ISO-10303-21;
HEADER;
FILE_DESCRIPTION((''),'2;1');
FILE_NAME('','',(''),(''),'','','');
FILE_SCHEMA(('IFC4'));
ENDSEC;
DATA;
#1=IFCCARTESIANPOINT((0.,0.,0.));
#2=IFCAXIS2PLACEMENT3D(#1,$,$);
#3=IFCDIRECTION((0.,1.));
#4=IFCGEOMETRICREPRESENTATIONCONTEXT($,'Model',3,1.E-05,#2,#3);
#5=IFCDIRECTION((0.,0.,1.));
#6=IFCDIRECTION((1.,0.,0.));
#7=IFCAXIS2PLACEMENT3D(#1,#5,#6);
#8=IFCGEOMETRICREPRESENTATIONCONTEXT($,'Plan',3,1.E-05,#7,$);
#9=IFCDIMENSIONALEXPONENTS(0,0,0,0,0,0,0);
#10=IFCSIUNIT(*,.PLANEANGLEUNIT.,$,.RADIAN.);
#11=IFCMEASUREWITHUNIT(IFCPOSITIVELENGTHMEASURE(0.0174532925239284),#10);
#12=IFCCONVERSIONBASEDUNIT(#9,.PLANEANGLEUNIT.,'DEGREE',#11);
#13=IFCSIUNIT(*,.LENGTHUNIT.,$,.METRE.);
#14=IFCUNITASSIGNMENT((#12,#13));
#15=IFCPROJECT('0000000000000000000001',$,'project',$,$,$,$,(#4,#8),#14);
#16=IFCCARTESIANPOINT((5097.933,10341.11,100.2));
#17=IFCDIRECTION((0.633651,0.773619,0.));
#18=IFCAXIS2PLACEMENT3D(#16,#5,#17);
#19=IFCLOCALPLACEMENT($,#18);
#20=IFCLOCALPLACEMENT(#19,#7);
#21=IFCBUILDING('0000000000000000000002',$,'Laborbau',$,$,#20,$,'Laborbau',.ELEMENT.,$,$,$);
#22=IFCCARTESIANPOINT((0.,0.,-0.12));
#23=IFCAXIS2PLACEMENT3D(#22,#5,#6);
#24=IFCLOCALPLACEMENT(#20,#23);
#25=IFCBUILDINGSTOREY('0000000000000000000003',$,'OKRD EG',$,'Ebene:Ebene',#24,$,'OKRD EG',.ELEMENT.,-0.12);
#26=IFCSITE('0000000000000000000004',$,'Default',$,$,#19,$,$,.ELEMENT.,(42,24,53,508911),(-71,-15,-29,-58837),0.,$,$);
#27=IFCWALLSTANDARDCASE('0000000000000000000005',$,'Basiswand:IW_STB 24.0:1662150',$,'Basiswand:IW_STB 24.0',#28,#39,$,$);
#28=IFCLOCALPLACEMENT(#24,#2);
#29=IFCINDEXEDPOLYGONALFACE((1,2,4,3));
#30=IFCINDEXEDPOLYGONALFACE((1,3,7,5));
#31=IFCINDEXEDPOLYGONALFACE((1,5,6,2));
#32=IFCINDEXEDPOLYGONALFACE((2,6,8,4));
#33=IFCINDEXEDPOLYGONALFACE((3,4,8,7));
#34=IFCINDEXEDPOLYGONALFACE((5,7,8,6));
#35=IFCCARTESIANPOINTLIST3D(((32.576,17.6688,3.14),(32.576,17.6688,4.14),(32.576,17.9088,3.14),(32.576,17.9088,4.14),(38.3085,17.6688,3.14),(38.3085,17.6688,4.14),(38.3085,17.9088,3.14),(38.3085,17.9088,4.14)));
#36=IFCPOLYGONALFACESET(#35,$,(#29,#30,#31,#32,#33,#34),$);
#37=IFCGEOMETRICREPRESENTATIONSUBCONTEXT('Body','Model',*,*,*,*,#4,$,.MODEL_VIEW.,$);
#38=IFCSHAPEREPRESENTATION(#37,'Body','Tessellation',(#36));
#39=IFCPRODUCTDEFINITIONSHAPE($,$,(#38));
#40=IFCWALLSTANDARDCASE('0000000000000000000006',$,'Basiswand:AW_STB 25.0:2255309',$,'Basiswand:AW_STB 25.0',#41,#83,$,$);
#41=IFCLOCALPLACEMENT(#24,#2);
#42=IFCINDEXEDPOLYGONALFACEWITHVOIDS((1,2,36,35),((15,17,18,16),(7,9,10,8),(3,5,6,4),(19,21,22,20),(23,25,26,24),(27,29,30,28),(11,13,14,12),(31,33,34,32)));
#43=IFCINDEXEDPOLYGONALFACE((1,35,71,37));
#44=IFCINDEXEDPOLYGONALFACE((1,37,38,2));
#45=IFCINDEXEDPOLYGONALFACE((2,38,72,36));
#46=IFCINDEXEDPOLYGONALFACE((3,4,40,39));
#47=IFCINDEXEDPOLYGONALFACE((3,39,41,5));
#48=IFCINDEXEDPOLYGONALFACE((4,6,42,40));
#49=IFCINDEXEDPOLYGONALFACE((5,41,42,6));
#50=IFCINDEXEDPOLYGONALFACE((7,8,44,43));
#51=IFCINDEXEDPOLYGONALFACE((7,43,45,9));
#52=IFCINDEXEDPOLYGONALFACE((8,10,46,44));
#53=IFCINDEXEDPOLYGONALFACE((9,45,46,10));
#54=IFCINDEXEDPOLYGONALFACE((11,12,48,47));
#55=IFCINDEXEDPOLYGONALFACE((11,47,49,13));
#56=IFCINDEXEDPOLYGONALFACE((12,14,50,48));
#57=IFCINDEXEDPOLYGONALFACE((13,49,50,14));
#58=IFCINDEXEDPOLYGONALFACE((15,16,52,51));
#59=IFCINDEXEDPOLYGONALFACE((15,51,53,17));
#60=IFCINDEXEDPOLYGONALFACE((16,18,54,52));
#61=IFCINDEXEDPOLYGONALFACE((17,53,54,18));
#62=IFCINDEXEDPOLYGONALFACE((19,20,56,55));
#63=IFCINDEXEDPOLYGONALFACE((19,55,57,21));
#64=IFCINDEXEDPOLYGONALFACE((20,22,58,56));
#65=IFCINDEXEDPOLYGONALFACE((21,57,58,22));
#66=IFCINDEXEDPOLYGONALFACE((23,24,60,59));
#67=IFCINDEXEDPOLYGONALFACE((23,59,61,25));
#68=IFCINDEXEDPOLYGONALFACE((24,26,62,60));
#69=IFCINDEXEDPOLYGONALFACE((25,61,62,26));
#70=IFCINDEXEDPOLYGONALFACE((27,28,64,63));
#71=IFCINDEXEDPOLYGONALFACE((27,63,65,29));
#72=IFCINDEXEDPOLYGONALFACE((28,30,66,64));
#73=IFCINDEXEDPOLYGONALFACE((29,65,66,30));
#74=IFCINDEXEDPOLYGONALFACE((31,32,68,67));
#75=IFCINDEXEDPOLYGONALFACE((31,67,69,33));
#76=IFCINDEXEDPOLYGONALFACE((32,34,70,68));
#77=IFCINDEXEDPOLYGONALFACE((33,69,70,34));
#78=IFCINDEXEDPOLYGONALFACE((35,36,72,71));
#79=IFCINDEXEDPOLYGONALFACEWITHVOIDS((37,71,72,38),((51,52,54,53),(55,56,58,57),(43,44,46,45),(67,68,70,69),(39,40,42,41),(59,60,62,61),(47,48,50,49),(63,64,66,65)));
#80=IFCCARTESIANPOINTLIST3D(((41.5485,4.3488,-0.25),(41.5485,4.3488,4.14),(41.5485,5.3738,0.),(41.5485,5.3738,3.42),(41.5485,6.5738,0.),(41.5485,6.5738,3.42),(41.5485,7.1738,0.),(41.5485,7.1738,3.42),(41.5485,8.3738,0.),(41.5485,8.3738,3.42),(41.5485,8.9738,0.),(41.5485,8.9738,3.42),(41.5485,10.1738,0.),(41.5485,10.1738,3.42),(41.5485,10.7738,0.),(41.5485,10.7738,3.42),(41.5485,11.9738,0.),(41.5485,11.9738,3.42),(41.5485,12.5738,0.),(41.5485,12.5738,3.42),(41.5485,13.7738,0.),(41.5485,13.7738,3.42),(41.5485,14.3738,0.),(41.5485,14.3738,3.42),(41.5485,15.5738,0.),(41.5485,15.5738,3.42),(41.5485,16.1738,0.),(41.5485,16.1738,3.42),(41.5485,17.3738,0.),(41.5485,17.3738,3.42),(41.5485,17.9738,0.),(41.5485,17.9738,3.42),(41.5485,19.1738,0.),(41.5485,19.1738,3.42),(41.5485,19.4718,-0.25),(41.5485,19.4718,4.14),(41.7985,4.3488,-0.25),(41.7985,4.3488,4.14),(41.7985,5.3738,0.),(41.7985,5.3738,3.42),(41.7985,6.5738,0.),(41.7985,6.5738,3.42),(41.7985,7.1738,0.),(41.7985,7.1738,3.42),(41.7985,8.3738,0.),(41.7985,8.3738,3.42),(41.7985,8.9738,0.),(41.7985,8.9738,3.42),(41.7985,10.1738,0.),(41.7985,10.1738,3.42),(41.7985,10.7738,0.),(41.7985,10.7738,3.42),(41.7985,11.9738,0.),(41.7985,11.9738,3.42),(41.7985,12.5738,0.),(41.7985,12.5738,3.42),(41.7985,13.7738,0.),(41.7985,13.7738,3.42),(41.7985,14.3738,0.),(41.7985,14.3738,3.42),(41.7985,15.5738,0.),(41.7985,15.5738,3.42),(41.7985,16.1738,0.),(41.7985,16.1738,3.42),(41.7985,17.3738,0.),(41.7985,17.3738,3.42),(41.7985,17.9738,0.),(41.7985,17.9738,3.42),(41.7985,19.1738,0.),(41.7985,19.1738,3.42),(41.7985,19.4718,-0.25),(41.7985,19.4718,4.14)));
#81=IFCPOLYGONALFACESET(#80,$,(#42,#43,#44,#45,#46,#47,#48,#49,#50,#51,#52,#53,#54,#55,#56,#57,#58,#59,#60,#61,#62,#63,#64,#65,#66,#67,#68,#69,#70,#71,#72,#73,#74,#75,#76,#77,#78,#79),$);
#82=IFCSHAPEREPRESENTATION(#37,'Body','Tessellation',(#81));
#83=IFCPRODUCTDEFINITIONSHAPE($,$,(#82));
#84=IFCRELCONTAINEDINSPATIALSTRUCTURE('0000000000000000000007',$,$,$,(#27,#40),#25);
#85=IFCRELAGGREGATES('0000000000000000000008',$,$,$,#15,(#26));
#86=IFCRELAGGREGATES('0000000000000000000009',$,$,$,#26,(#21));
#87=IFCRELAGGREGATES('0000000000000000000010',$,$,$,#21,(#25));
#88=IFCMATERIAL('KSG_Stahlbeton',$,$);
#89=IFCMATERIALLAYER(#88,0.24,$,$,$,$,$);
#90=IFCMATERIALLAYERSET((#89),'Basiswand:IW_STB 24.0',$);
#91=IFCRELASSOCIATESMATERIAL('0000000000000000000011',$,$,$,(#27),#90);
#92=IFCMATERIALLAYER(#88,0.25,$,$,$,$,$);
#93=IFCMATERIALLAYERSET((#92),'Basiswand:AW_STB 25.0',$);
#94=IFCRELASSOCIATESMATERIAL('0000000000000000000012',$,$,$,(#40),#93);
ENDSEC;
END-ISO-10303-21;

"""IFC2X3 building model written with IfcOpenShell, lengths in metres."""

from ifc_helpers import new_model, entity, si_unit, converted_unit, direction, frame, frame_2d, origin, origin_with_axes, place, context, subcontext, project, spatial, rectangle, extrude, material, layer, layer_set, layer_usage, element, save


model = new_model("IFC2X3")

# Units and contexts
model_context = context("Model", 3, precision=1e-05, world=origin(), true_north=direction((0.0, 1.0)))
plan_context = context("Plan", 3, precision=1e-05, world=origin_with_axes())
body_context = subcontext(model_context, "Body", "Model", "MODEL_VIEW")
ifc_project = project(units=[converted_unit("PLANEANGLEUNIT", "DEGREE", entity("IfcPositiveLengthMeasure", 0.0174532925239284), si_unit("PLANEANGLEUNIT", "RADIAN"), dimensions=[0, 0, 0, 0, 0, 0, 0]), si_unit("LENGTHUNIT", "METRE")], contexts=[model_context, plan_context])

# Site, building, storey
site_placement = place(None, frame((5097.933, 10341.11, 100.2), z_axis=(0.0, 0.0, 1.0), x_axis=(0.633651, 0.773619, 0.0)))
site = spatial("IfcSite", under=ifc_project, at=site_placement, Name="Default", CompositionType="ELEMENT", RefLatitude=(42, 24, 53, 508911), RefLongitude=(-71, -15, -29, -58837), RefElevation=0.0)
building_placement = place(site_placement, origin_with_axes())
building = spatial("IfcBuilding", under=site, at=building_placement, Name="Laborbau", LongName="Laborbau", CompositionType="ELEMENT")
storey_placement = place(building_placement, frame((0.0, 0.0, -0.12), z_axis=(0.0, 0.0, 1.0), x_axis=(1.0, 0.0, 0.0)))
storey = spatial("IfcBuildingStorey", under=building, at=storey_placement, Name="OKRD EG", ObjectType="Ebene:Ebene", LongName="OKRD EG", CompositionType="ELEMENT", Elevation=-0.12)

# Shared definitions
ifc_material_1 = material(Name="KSG_Stahlbeton")

# Shared definitions
ifc_layer_1 = layer(ifc_material_1, 0.25)
ifc_layer_set_1 = layer_set([ifc_layer_1], Name="Basiswand:AW_STB 25.0")

# Wall
ifc_layer_2 = layer(ifc_material_1, 0.24)
ifc_layer_set_2 = layer_set([ifc_layer_2], Name="Basiswand:IW_STB 24.0")
ifc_layer_usage_1 = layer_usage(ifc_layer_set_2, "AXIS2", "POSITIVE", -0.12)
wall_1_placement = place(storey_placement, frame((32.576, 17.7888, 3.14), z_axis=(0.0, 0.0, 1.0), x_axis=(1.0, 0.0, 0.0)))
element("IfcWallStandardCase", 1, at=wall_1_placement, inside=storey, material=ifc_layer_usage_1, Name="Basiswand:IW_STB 24.0:1662150", ObjectType="Basiswand:IW_STB 24.0", context=body_context, shape_type="SweptSolid", body=[
    extrude(rectangle(XDim=5.7325, YDim=0.24, at=frame_2d((2.8663, 0.0), x_axis=(-1.0, 0.0))), origin(), (0.0, 0.0, 1.0), 1.0),
])

# Wall, openings
ifc_layer_usage_2 = layer_usage(ifc_layer_set_1, "AXIS2", "NEGATIVE", 0.125)
wall_2_placement = place(storey_placement, frame((41.6735, 19.4718, -0.25), z_axis=(0.0, 0.0, 1.0), x_axis=(0.0, -1.0, 0.0)))
wall_2 = element("IfcWallStandardCase", 2, at=wall_2_placement, inside=storey, material=ifc_layer_usage_2, Name="Basiswand:AW_STB 25.0:2255309", ObjectType="Basiswand:AW_STB 25.0", context=body_context, shape_type="SweptSolid", body=[
    extrude(rectangle(XDim=15.123, YDim=0.25, at=frame_2d((7.5615, 0.0), x_axis=(-1.0, 0.0))), origin(), (0.0, 0.0, 1.0), 4.39),
])
opening_1_placement = place(wall_2_placement, frame((19.4718, -41.6735, 0.25), z_axis=(0.0, 0.0, 1.0), x_axis=(0.0, 1.0, 0.0)))
element("IfcOpeningElement", 3, at=opening_1_placement, cuts=wall_2, ObjectType="Opening", context=body_context, shape_type="SweptSolid", body=[
    extrude(rectangle(XDim=3.42, YDim=1.2, at=frame_2d((0.0, 0.0), x_axis=(0.0, 1.0))), frame((41.5485, 13.1738, 1.71), z_axis=(1.0, 0.0, 0.0), x_axis=(0.0, -1.0, 0.0)), (0.0, 0.0, 1.0), 0.25),
])
opening_2_placement = place(wall_2_placement, frame((19.4718, -41.6735, 0.25), z_axis=(0.0, 0.0, 1.0), x_axis=(0.0, 1.0, 0.0)))
element("IfcOpeningElement", 4, at=opening_2_placement, cuts=wall_2, ObjectType="Opening", context=body_context, shape_type="SweptSolid", body=[
    extrude(rectangle(XDim=3.42, YDim=1.2, at=frame_2d((0.0, 0.0), x_axis=(1.0, 0.0))), frame((41.5485, 11.3738, 1.71), z_axis=(1.0, 0.0, 0.0), x_axis=(0.0, 0.0, -1.0)), (0.0, 0.0, 1.0), 0.25),
])
opening_3_placement = place(wall_2_placement, frame((19.4718, -41.6735, 0.25), z_axis=(0.0, 0.0, 1.0), x_axis=(0.0, 1.0, 0.0)))
element("IfcOpeningElement", 5, at=opening_3_placement, cuts=wall_2, ObjectType="Opening", context=body_context, shape_type="SweptSolid", body=[
    extrude(rectangle(XDim=3.42, YDim=1.2, at=frame_2d((0.0, 0.0), x_axis=(0.0, 1.0))), frame((41.5485, 9.5738, 1.71), z_axis=(1.0, 0.0, 0.0), x_axis=(0.0, -1.0, 0.0)), (0.0, 0.0, 1.0), 0.25),
])
opening_4_placement = place(wall_2_placement, frame((19.4718, -41.6735, 0.25), z_axis=(0.0, 0.0, 1.0), x_axis=(0.0, 1.0, 0.0)))
element("IfcOpeningElement", 6, at=opening_4_placement, cuts=wall_2, ObjectType="Opening", context=body_context, shape_type="SweptSolid", body=[
    extrude(rectangle(XDim=3.42, YDim=1.2, at=frame_2d((0.0, 0.0), x_axis=(1.0, 0.0))), frame((41.5485, 7.7738, 1.71), z_axis=(1.0, 0.0, 0.0), x_axis=(0.0, 0.0, -1.0)), (0.0, 0.0, 1.0), 0.25),
])
opening_5_placement = place(wall_2_placement, frame((19.4718, -41.6735, 0.25), z_axis=(0.0, 0.0, 1.0), x_axis=(0.0, 1.0, 0.0)))
element("IfcOpeningElement", 7, at=opening_5_placement, cuts=wall_2, ObjectType="Opening", context=body_context, shape_type="SweptSolid", body=[
    extrude(rectangle(XDim=3.42, YDim=1.2, at=frame_2d((0.0, 0.0), x_axis=(0.0, 1.0))), frame((41.5485, 5.9738, 1.71), z_axis=(1.0, 0.0, 0.0), x_axis=(0.0, -1.0, 0.0)), (0.0, 0.0, 1.0), 0.25),
])
opening_6_placement = place(wall_2_placement, frame((19.4718, -41.6735, 0.25), z_axis=(0.0, 0.0, 1.0), x_axis=(0.0, 1.0, 0.0)))
element("IfcOpeningElement", 8, at=opening_6_placement, cuts=wall_2, ObjectType="Opening", context=body_context, shape_type="SweptSolid", body=[
    extrude(rectangle(XDim=3.42, YDim=1.2, at=frame_2d((0.0, 0.0), x_axis=(1.0, 0.0))), frame((41.5485, 18.5738, 1.71), z_axis=(1.0, 0.0, 0.0), x_axis=(0.0, 0.0, -1.0)), (0.0, 0.0, 1.0), 0.25),
])
opening_7_placement = place(wall_2_placement, frame((19.4718, -41.6735, 0.25), z_axis=(0.0, 0.0, 1.0), x_axis=(0.0, 1.0, 0.0)))
element("IfcOpeningElement", 9, at=opening_7_placement, cuts=wall_2, ObjectType="Opening", context=body_context, shape_type="SweptSolid", body=[
    extrude(rectangle(XDim=3.42, YDim=1.2, at=frame_2d((0.0, 0.0), x_axis=(0.0, 1.0))), frame((41.5485, 16.7738, 1.71), z_axis=(1.0, 0.0, 0.0), x_axis=(0.0, -1.0, 0.0)), (0.0, 0.0, 1.0), 0.25),
])
opening_8_placement = place(wall_2_placement, frame((19.4718, -41.6735, 0.25), z_axis=(0.0, 0.0, 1.0), x_axis=(0.0, 1.0, 0.0)))
element("IfcOpeningElement", 10, at=opening_8_placement, cuts=wall_2, ObjectType="Opening", context=body_context, shape_type="SweptSolid", body=[
    extrude(rectangle(XDim=3.42, YDim=1.2, at=frame_2d((0.0, 0.0), x_axis=(1.0, 0.0))), frame((41.5485, 14.9738, 1.71), z_axis=(1.0, 0.0, 0.0), x_axis=(0.0, 0.0, -1.0)), (0.0, 0.0, 1.0), 0.25),
])

save(model, "model.ifc")
